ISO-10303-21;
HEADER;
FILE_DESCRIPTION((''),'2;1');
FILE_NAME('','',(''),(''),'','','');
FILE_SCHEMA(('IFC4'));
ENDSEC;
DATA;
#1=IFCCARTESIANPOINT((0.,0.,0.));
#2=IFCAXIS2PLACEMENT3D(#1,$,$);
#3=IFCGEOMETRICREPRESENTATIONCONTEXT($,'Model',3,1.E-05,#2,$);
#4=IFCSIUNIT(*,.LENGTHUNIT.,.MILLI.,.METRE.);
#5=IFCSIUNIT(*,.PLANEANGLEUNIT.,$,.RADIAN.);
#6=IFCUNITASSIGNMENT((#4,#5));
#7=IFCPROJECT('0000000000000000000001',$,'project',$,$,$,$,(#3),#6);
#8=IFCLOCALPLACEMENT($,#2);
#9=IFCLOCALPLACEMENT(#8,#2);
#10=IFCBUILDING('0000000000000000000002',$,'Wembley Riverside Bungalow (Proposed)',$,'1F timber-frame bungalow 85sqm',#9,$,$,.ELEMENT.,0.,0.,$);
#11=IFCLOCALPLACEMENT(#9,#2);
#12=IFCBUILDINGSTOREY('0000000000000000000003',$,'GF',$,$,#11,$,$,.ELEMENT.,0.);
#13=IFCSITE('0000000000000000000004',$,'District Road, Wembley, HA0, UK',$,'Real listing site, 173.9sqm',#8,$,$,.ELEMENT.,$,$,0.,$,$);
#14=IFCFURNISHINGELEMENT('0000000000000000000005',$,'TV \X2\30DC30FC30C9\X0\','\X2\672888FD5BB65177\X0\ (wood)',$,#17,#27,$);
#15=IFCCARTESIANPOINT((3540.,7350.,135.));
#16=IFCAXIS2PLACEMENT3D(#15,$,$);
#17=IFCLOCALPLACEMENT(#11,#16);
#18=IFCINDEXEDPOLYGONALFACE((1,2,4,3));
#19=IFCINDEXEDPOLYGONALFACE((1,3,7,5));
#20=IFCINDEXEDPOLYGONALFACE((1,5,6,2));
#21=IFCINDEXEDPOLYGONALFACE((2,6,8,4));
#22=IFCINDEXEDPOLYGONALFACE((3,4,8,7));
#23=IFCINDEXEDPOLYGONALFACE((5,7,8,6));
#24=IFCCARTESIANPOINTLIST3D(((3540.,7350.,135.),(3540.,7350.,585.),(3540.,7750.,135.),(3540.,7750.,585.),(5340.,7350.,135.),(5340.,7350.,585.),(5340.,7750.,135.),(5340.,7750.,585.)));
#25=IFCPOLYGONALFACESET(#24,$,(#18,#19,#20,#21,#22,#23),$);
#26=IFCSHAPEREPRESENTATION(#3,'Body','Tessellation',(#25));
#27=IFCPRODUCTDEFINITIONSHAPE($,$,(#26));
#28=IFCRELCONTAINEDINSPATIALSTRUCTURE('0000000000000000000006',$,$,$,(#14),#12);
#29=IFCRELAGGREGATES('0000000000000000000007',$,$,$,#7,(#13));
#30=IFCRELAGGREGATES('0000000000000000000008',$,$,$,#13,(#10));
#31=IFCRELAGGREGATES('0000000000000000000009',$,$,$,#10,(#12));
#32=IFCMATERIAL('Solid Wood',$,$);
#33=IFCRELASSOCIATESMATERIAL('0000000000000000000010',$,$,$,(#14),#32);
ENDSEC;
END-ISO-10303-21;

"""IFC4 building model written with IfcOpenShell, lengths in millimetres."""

from ifc_helpers import new_model, si_unit, frame, frame_2d, origin, place, context, project, spatial, rectangle, extrude, material, element, save


model = new_model("IFC4")

# Units and contexts
model_context = context("Model", 3, precision=1e-05, world=origin())
ifc_project = project(units=[si_unit("LENGTHUNIT", "METRE", prefix="MILLI"), si_unit("PLANEANGLEUNIT", "RADIAN")], contexts=[model_context])

# Site, building, storey
site_placement = place(None, origin())
site = spatial("IfcSite", under=ifc_project, at=site_placement, Name="District Road, Wembley, HA0, UK", ObjectType="Real listing site, 173.9sqm", CompositionType="ELEMENT", RefElevation=0.0)
building_placement = place(site_placement, origin())
building = spatial("IfcBuilding", under=site, at=building_placement, Name="Wembley Riverside Bungalow (Proposed)", ObjectType="1F timber-frame bungalow 85sqm", CompositionType="ELEMENT", ElevationOfRefHeight=0.0, ElevationOfTerrain=0.0)
storey_placement = place(building_placement, origin())
storey = spatial("IfcBuildingStorey", under=building, at=storey_placement, Name="GF", CompositionType="ELEMENT", Elevation=0.0)

# Shared definitions
ifc_material_1 = material(Name="Solid Wood")

# Furnishing element
furnishing_1_placement = place(storey_placement, frame((3540.0, 7350.0, 135.0)))
element("IfcFurnishingElement", 1, at=furnishing_1_placement, inside=storey, material=ifc_material_1, Name="TV ボード", Description="木製家具 (wood)", context=model_context, shape_type="SweptSolid", body=[
    extrude(rectangle(XDim=1800.0, YDim=400.0, at=frame_2d((900.0, 200.0))), frame((3540.0, 7350.0, 135.0)), (0.0, 0.0, 1.0), 450.0),
])

save(model, "model.ifc")
